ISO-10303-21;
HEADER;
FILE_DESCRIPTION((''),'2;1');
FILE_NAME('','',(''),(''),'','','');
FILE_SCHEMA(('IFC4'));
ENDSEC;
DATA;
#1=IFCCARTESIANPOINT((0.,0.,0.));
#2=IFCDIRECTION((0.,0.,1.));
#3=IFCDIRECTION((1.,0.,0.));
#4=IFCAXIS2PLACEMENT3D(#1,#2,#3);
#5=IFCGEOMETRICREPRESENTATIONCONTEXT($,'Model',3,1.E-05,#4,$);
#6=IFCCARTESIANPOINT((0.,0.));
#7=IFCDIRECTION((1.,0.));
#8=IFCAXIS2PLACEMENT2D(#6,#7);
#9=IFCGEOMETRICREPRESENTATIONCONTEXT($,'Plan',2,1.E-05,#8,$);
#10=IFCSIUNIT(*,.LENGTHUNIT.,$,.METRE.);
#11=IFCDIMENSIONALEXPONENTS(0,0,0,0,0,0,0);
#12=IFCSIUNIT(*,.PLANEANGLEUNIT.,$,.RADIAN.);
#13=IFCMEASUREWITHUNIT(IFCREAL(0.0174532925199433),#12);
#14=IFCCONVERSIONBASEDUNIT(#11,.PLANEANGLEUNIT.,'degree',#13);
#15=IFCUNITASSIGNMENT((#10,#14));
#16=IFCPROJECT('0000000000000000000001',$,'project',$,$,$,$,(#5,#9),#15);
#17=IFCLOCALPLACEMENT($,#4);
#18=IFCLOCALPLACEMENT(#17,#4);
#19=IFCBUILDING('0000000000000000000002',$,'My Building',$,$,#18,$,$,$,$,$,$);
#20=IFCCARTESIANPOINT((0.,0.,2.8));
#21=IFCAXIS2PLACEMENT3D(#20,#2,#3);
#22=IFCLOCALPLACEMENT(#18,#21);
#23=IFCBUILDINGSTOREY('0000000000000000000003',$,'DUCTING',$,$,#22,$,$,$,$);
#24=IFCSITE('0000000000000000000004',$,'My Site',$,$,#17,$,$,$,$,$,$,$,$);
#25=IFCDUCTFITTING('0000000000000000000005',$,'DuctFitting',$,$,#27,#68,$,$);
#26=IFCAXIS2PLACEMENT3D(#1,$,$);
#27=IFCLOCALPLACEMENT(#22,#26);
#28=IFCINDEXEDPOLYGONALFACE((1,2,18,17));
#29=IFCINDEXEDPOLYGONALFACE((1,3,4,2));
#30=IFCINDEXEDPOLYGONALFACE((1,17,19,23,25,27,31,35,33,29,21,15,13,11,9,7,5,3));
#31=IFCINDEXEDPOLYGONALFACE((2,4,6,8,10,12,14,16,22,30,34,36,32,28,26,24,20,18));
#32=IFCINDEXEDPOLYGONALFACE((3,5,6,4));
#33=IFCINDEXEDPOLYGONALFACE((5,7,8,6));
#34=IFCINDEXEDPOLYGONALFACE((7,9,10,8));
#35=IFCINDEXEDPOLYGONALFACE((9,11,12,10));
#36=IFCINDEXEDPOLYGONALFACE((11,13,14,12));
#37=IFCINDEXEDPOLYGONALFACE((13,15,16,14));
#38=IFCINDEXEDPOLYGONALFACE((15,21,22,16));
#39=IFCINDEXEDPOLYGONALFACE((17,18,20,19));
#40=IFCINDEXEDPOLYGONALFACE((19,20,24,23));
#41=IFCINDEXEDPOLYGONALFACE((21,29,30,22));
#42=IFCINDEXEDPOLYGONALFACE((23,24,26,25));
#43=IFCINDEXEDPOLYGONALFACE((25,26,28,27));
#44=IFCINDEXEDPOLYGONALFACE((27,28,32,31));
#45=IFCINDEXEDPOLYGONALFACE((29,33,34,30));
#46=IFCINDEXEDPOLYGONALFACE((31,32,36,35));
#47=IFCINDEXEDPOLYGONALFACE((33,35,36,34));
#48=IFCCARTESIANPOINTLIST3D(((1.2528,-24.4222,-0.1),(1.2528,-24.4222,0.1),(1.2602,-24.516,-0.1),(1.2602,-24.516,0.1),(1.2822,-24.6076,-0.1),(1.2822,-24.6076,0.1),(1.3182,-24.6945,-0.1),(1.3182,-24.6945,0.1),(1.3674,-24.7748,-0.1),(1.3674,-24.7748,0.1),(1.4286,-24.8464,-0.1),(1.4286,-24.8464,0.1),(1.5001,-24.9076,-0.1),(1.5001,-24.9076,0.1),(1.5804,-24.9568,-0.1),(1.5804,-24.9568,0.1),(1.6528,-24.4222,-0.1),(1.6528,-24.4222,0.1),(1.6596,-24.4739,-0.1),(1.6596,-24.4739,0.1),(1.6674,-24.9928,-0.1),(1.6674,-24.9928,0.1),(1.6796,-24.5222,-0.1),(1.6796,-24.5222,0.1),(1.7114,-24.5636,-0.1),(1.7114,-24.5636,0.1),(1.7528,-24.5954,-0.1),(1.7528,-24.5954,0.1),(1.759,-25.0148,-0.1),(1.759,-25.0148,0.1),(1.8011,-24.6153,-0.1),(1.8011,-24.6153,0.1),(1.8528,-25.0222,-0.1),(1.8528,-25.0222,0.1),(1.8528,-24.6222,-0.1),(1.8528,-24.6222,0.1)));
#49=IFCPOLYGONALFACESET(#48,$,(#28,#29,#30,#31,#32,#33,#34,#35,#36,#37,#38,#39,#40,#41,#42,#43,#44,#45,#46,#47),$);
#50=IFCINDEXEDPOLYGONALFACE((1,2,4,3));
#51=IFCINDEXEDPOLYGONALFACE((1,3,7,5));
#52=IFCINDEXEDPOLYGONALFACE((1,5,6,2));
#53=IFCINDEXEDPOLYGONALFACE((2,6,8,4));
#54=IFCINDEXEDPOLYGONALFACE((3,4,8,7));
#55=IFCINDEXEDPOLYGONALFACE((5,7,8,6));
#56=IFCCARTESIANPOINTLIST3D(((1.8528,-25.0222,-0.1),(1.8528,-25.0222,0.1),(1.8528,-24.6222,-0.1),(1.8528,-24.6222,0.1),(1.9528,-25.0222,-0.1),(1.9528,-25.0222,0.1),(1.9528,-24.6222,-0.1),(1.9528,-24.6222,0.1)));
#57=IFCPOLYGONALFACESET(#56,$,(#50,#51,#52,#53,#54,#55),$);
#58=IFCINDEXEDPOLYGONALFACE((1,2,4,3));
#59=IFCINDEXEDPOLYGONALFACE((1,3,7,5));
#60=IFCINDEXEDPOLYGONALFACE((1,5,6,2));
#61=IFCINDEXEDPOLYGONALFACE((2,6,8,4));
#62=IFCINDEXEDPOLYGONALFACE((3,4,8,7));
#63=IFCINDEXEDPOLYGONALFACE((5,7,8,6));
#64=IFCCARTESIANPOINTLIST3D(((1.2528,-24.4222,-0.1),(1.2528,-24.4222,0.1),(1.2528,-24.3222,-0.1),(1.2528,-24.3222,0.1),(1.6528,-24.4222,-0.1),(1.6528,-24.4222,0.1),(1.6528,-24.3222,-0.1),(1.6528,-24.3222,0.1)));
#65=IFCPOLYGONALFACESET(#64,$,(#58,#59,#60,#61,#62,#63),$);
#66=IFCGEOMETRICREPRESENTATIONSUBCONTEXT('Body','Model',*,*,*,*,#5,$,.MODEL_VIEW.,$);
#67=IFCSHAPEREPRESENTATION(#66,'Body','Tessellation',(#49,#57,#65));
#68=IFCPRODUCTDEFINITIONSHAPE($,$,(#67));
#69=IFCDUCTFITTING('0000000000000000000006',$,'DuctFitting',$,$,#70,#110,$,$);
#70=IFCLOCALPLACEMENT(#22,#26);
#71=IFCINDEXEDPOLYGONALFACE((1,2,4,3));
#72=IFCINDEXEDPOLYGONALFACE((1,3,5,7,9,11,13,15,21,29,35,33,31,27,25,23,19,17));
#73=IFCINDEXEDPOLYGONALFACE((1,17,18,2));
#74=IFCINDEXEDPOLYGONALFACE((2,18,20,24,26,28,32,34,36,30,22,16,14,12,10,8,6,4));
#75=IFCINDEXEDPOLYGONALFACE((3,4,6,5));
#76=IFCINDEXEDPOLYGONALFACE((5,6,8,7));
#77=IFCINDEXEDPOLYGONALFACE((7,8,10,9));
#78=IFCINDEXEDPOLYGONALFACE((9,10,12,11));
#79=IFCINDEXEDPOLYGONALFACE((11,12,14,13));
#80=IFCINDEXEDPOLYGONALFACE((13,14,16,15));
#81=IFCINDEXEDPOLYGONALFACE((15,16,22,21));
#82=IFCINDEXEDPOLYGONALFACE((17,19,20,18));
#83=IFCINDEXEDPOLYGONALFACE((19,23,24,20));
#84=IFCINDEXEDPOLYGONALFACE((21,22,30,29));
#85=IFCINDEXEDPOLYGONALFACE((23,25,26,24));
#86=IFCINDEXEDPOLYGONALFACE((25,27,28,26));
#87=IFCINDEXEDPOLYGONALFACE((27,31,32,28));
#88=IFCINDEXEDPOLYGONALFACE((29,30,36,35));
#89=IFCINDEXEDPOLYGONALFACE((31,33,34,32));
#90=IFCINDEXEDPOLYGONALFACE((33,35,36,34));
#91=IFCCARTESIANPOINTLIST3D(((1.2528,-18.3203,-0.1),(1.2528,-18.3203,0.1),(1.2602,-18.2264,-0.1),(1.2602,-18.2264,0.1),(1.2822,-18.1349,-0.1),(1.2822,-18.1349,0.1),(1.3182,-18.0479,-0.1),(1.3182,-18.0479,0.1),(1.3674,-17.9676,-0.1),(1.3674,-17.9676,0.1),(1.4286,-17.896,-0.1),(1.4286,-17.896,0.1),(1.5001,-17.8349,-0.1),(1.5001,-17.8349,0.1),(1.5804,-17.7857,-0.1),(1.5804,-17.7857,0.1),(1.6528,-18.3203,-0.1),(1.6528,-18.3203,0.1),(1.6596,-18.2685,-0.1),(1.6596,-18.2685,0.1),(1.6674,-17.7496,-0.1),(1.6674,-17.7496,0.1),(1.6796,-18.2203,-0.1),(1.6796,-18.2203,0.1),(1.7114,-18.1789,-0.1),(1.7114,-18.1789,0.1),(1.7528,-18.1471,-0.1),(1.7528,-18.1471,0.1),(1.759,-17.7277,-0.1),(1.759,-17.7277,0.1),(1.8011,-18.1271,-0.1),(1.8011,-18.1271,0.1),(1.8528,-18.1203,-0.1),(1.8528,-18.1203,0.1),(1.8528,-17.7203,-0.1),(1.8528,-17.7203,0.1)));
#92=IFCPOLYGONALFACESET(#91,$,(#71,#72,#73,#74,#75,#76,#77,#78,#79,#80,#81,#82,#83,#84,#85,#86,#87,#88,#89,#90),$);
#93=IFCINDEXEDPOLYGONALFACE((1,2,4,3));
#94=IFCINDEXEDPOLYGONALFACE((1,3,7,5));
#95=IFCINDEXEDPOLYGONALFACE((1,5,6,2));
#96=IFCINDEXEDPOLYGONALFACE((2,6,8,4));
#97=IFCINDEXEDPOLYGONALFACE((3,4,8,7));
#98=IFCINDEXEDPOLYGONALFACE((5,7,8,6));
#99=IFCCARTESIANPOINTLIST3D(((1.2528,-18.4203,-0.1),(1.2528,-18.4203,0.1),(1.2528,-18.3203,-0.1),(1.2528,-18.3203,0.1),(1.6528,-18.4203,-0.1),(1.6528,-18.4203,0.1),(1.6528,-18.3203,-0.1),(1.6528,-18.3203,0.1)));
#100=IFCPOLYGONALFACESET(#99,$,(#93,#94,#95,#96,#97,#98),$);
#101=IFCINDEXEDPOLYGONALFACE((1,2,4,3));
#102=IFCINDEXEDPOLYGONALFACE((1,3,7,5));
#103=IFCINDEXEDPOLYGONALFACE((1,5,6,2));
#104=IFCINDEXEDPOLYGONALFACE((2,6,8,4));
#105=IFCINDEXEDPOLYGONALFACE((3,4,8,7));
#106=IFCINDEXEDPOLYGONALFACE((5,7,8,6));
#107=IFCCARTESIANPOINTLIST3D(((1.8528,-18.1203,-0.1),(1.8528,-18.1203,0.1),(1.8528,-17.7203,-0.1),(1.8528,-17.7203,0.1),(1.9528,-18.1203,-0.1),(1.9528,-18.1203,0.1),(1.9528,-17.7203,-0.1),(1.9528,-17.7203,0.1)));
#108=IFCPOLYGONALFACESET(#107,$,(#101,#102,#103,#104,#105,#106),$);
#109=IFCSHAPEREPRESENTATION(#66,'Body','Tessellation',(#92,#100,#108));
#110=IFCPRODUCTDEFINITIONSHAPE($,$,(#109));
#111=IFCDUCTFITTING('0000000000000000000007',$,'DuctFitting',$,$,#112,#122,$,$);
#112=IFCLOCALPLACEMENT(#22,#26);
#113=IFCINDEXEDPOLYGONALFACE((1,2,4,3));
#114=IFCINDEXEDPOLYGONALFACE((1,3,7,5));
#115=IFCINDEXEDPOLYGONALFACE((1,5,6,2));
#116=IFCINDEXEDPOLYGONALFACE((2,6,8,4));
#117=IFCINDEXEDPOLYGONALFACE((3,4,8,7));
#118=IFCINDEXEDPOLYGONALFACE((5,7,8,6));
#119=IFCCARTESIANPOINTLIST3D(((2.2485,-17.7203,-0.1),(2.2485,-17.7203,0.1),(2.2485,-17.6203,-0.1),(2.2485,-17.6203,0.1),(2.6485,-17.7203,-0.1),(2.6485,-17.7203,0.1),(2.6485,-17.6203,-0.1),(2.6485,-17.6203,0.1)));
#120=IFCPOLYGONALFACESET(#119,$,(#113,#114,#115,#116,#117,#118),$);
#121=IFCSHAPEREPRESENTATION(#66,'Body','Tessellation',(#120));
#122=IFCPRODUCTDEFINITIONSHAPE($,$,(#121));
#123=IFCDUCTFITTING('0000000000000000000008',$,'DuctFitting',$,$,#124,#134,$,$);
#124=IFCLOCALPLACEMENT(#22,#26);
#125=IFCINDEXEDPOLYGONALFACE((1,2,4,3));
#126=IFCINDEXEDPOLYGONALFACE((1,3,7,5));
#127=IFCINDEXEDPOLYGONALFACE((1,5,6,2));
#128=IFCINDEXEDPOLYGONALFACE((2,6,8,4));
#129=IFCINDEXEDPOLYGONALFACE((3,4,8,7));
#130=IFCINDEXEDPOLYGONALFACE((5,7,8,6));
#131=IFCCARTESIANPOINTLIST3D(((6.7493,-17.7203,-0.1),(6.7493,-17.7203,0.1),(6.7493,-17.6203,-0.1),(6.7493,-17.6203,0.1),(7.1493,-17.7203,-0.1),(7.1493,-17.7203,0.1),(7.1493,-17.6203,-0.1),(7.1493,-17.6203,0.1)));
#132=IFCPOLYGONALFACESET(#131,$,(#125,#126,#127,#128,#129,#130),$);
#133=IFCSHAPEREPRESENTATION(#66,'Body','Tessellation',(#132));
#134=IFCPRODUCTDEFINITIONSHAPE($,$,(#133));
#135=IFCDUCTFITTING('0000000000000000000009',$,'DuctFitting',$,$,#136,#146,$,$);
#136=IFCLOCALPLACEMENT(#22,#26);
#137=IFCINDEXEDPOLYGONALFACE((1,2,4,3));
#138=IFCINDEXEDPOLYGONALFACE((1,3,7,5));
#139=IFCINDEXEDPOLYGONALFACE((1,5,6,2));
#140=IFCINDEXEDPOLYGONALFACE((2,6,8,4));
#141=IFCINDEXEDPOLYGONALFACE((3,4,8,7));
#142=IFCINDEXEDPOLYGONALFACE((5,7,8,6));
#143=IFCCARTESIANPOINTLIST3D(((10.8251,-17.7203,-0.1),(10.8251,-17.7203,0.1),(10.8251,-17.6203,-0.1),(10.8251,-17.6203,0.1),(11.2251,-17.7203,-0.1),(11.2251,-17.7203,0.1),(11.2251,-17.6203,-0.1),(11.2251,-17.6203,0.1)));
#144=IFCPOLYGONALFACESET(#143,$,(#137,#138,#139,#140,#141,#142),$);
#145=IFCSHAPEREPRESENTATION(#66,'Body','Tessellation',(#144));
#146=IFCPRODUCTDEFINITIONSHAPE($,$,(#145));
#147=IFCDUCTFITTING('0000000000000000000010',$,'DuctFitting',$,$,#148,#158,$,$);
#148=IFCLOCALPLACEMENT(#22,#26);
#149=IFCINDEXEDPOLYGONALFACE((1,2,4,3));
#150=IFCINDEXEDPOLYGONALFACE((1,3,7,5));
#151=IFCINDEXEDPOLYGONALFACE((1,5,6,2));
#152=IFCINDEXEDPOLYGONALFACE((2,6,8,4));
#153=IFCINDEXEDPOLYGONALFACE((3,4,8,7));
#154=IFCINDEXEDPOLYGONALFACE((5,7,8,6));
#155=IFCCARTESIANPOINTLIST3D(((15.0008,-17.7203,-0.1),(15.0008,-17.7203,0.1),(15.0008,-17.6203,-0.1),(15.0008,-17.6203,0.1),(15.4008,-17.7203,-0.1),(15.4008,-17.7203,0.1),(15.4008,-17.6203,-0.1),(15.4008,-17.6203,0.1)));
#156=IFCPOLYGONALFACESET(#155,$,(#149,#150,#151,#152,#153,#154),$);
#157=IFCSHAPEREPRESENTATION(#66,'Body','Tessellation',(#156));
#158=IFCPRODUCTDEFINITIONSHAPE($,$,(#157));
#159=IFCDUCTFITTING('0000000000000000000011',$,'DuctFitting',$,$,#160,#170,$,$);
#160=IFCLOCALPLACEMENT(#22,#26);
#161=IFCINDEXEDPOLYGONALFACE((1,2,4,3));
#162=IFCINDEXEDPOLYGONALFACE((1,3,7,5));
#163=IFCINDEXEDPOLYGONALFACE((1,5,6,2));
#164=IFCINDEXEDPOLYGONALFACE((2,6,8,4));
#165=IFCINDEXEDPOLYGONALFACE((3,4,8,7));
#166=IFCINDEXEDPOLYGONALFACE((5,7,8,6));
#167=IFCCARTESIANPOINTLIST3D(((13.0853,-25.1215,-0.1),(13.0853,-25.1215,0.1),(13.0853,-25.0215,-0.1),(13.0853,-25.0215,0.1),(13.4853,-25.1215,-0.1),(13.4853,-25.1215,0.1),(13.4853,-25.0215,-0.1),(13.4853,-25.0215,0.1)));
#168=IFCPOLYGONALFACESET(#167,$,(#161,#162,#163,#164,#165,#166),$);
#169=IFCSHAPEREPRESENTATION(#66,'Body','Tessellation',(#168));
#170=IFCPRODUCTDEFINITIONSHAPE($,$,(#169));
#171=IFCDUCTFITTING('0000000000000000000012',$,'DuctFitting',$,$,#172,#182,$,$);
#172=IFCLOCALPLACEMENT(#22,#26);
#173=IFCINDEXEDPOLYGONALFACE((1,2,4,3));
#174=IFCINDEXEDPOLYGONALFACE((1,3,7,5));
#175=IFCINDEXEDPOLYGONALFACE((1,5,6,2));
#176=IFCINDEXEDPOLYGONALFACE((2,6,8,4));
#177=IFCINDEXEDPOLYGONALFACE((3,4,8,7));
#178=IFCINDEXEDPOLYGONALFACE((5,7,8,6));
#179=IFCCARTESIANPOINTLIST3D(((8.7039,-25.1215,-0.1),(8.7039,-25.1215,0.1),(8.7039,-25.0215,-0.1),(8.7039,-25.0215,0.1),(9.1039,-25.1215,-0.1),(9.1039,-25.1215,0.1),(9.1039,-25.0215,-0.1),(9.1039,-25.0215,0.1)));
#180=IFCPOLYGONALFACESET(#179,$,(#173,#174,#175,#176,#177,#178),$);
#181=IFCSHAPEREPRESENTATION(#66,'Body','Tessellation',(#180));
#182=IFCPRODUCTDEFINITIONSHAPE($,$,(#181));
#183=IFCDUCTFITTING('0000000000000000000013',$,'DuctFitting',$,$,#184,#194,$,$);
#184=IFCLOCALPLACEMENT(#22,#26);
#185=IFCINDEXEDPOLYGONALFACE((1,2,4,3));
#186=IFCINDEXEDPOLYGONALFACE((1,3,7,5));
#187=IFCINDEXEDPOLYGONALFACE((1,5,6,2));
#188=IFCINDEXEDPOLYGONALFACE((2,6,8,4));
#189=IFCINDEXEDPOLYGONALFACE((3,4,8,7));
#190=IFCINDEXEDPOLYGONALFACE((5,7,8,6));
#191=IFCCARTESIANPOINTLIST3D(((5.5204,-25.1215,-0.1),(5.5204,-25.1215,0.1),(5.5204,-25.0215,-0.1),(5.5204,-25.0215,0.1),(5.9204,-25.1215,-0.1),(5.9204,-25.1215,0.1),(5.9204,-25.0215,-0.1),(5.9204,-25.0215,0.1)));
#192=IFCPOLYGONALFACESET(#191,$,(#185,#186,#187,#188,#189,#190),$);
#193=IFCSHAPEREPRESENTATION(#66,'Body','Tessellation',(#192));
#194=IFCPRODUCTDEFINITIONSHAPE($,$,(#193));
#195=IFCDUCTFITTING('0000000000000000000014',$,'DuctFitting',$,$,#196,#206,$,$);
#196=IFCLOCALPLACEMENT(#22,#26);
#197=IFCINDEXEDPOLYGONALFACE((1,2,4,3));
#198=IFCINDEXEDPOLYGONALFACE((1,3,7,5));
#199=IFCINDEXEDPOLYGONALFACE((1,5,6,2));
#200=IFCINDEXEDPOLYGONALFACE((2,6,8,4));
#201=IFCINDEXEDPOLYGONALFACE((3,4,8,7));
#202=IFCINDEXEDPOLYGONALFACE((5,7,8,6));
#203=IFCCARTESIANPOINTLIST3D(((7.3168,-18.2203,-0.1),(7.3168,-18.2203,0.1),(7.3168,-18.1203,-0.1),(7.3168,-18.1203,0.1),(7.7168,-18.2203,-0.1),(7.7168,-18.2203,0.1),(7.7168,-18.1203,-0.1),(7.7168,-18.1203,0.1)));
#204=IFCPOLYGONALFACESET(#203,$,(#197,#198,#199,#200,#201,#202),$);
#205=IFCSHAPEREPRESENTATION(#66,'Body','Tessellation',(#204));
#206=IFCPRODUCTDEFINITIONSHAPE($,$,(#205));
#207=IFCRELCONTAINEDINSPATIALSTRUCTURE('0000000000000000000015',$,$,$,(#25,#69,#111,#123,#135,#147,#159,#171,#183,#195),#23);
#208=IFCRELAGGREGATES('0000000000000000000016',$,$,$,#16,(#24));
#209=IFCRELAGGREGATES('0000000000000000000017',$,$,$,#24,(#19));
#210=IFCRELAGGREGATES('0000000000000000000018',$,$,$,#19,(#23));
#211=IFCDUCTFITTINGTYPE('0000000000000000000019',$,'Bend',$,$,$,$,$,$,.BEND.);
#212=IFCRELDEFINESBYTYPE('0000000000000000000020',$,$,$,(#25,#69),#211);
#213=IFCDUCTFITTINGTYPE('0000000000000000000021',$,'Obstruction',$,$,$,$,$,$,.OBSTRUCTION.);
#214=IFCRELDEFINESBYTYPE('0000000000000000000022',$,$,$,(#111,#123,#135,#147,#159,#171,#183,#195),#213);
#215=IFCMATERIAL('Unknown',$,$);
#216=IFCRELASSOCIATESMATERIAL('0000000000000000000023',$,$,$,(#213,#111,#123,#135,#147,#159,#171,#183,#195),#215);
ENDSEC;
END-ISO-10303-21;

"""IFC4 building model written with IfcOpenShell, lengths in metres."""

from ifc_helpers import new_model, entity, si_unit, converted_unit, frame, origin_with_axes, origin_2d_with_axis, place, context, subcontext, project, spatial, line, arc, indexed_curve, rectangle, outline, extrude, source, transform, mapped, material, material_profile, profile_set, profile_usage, type_object, type_shapes, element, save


model = new_model("IFC4")

# Units and contexts
model_context = context("Model", 3, precision=1e-05, world=origin_with_axes())
plan_context = context("Plan", 2, precision=1e-05, world=origin_2d_with_axis())
body_context = subcontext(model_context, "Body", "Model", "MODEL_VIEW")
ifc_project = project(units=[si_unit("LENGTHUNIT", "METRE"), converted_unit("PLANEANGLEUNIT", "degree", entity("IfcReal", 0.0174532925199433), si_unit("PLANEANGLEUNIT", "RADIAN"), dimensions=[0, 0, 0, 0, 0, 0, 0])], contexts=[model_context, plan_context])

# Site, building, storey
site_placement = place(None, origin_with_axes())
site = spatial("IfcSite", under=ifc_project, at=site_placement, Name="My Site")
building_placement = place(site_placement, origin_with_axes())
building = spatial("IfcBuilding", under=site, at=building_placement, Name="My Building")
storey_placement = place(building_placement, frame((0.0, 0.0, 2.8), z_axis=(0.0, 0.0, 1.0), x_axis=(1.0, 0.0, 0.0)))
storey = spatial("IfcBuildingStorey", under=building, at=storey_placement, Name="DUCTING")

# Shared definitions
ifc_material = material(Name="Unknown")

# Duct fittings
duct_fitting_type_1 = type_object("IfcDuctFittingType", Name="Bend", PredefinedType="BEND")
shared_shape = source(origin_with_axes(), body_context, "Body", "SweptSolid", [
    extrude(outline(indexed_curve([(-0.2, 0.0), (-0.2586, 0.1414), (-0.4, 0.2), (-0.4, 0.6), (0.0243, 0.4243), (0.2, 0.0)], segments=[arc(1, 2, 3), line(3, 4), arc(4, 5, 6), line(6, 1)])), frame((0.0, -0.1, 0.1), z_axis=(0.0, -1.0, 0.0), x_axis=(1.0, 0.0, 0.0)), (0.0, 0.0, -1.0), 0.2),
    extrude(rectangle(XDim=0.4, YDim=0.2), origin_with_axes(), (0.0, 0.0, 1.0), 0.1),
    extrude(rectangle(XDim=0.4, YDim=0.2), frame((-0.4, 0.0, 0.5), z_axis=(-1.0, 0.0, 0.0), x_axis=(0.0, 0.0, -1.0)), (0.0, 0.0, 1.0), 0.1),
])
type_shapes(duct_fitting_type_1, [shared_shape])
for number, where, z_axis, x_axis, name in (
    (1, (1.9528, -24.8222, 0.0), (-1.0, 0.0, 0.0), (0.0, -1.0, 0.0), "DuctFitting"),
    (2, (1.4528, -18.4203, 0.0), (0.0, 1.0, 0.0), (-1.0, 0.0, 0.0), "DuctFitting"),
):
    element("IfcDuctFitting", number, at=place(storey_placement, frame(where, z_axis=z_axis, x_axis=x_axis)), inside=storey, type_object=duct_fitting_type_1, Name=name, context=body_context, shape_type="MappedRepresentation", body=[
        mapped(shared_shape, transform((0.0, 0.0, 0.0), x_axis=(1.0, 0.0, 0.0), y_axis=(0.0, 1.0, 0.0), z_axis=(0.0, 0.0, 1.0), scale=1.0)),
    ])
ifc_material_profile_1 = material_profile(ifc_material, rectangle(XDim=0.4, YDim=0.2))
ifc_profile_set_1 = profile_set([ifc_material_profile_1])
ifc_profile_usage_1 = profile_usage(ifc_profile_set_1, cardinal=5)
duct_fitting_type_2 = type_object("IfcDuctFittingType", Name="Obstruction", PredefinedType="OBSTRUCTION", material=ifc_profile_set_1)
duct_fitting_1_placement = place(storey_placement, frame((2.4485, -17.6203, 0.0), z_axis=(0.0, -1.0, 0.0), x_axis=(1.0, 0.0, 0.0)))
element("IfcDuctFitting", 3, at=duct_fitting_1_placement, inside=storey, type_object=duct_fitting_type_2, material=ifc_profile_usage_1, Name="DuctFitting", context=body_context, shape_type="SweptSolid", body=[
    extrude(rectangle(XDim=0.4, YDim=0.2), origin_with_axes(), (0.0, 0.0, 1.0), 0.1),
])
ifc_profile_usage_2 = profile_usage(ifc_profile_set_1, cardinal=5)
duct_fitting_2_placement = place(storey_placement, frame((6.9493, -17.6203, 0.0), z_axis=(0.0, -1.0, 0.0), x_axis=(1.0, 0.0, 0.0)))
element("IfcDuctFitting", 4, at=duct_fitting_2_placement, inside=storey, type_object=duct_fitting_type_2, material=ifc_profile_usage_2, Name="DuctFitting", context=body_context, shape_type="SweptSolid", body=[
    extrude(rectangle(XDim=0.4, YDim=0.2), origin_with_axes(), (0.0, 0.0, 1.0), 0.1),
])
ifc_profile_usage_3 = profile_usage(ifc_profile_set_1, cardinal=5)
duct_fitting_3_placement = place(storey_placement, frame((11.0251, -17.6203, 0.0), z_axis=(0.0, -1.0, 0.0), x_axis=(1.0, 0.0, 0.0)))
element("IfcDuctFitting", 5, at=duct_fitting_3_placement, inside=storey, type_object=duct_fitting_type_2, material=ifc_profile_usage_3, Name="DuctFitting", context=body_context, shape_type="SweptSolid", body=[
    extrude(rectangle(XDim=0.4, YDim=0.2), origin_with_axes(), (0.0, 0.0, 1.0), 0.1),
])
ifc_profile_usage_4 = profile_usage(ifc_profile_set_1, cardinal=5)
duct_fitting_4_placement = place(storey_placement, frame((15.2008, -17.6203, 0.0), z_axis=(0.0, -1.0, 0.0), x_axis=(1.0, 0.0, 0.0)))
element("IfcDuctFitting", 6, at=duct_fitting_4_placement, inside=storey, type_object=duct_fitting_type_2, material=ifc_profile_usage_4, Name="DuctFitting", context=body_context, shape_type="SweptSolid", body=[
    extrude(rectangle(XDim=0.4, YDim=0.2), origin_with_axes(), (0.0, 0.0, 1.0), 0.1),
])
ifc_profile_usage_5 = profile_usage(ifc_profile_set_1, cardinal=5)
duct_fitting_5_placement = place(storey_placement, frame((13.2853, -25.1215, 0.0), z_axis=(0.0, 1.0, 0.0), x_axis=(-1.0, 0.0, 0.0)))
element("IfcDuctFitting", 7, at=duct_fitting_5_placement, inside=storey, type_object=duct_fitting_type_2, material=ifc_profile_usage_5, Name="DuctFitting", context=body_context, shape_type="SweptSolid", body=[
    extrude(rectangle(XDim=0.4, YDim=0.2), origin_with_axes(), (0.0, 0.0, 1.0), 0.1),
])
ifc_profile_usage_6 = profile_usage(ifc_profile_set_1, cardinal=5)
duct_fitting_6_placement = place(storey_placement, frame((8.9039, -25.1215, 0.0), z_axis=(0.0, 1.0, 0.0), x_axis=(-1.0, 0.0, 0.0)))
element("IfcDuctFitting", 8, at=duct_fitting_6_placement, inside=storey, type_object=duct_fitting_type_2, material=ifc_profile_usage_6, Name="DuctFitting", context=body_context, shape_type="SweptSolid", body=[
    extrude(rectangle(XDim=0.4, YDim=0.2), origin_with_axes(), (0.0, 0.0, 1.0), 0.1),
])
ifc_profile_usage_7 = profile_usage(ifc_profile_set_1, cardinal=5)
duct_fitting_7_placement = place(storey_placement, frame((5.7204, -25.1215, 0.0), z_axis=(0.0, 1.0, 0.0), x_axis=(-1.0, 0.0, 0.0)))
element("IfcDuctFitting", 9, at=duct_fitting_7_placement, inside=storey, type_object=duct_fitting_type_2, material=ifc_profile_usage_7, Name="DuctFitting", context=body_context, shape_type="SweptSolid", body=[
    extrude(rectangle(XDim=0.4, YDim=0.2), origin_with_axes(), (0.0, 0.0, 1.0), 0.1),
])
ifc_profile_usage_8 = profile_usage(ifc_profile_set_1, cardinal=5)
duct_fitting_8_placement = place(storey_placement, frame((7.5168, -18.2203, 0.0), z_axis=(0.0, 1.0, 0.0), x_axis=(-1.0, 0.0, 0.0)))
element("IfcDuctFitting", 10, at=duct_fitting_8_placement, inside=storey, type_object=duct_fitting_type_2, material=ifc_profile_usage_8, Name="DuctFitting", context=body_context, shape_type="SweptSolid", body=[
    extrude(rectangle(XDim=0.4, YDim=0.2), origin_with_axes(), (0.0, 0.0, 1.0), 0.1),
])

save(model, "model.ifc")
